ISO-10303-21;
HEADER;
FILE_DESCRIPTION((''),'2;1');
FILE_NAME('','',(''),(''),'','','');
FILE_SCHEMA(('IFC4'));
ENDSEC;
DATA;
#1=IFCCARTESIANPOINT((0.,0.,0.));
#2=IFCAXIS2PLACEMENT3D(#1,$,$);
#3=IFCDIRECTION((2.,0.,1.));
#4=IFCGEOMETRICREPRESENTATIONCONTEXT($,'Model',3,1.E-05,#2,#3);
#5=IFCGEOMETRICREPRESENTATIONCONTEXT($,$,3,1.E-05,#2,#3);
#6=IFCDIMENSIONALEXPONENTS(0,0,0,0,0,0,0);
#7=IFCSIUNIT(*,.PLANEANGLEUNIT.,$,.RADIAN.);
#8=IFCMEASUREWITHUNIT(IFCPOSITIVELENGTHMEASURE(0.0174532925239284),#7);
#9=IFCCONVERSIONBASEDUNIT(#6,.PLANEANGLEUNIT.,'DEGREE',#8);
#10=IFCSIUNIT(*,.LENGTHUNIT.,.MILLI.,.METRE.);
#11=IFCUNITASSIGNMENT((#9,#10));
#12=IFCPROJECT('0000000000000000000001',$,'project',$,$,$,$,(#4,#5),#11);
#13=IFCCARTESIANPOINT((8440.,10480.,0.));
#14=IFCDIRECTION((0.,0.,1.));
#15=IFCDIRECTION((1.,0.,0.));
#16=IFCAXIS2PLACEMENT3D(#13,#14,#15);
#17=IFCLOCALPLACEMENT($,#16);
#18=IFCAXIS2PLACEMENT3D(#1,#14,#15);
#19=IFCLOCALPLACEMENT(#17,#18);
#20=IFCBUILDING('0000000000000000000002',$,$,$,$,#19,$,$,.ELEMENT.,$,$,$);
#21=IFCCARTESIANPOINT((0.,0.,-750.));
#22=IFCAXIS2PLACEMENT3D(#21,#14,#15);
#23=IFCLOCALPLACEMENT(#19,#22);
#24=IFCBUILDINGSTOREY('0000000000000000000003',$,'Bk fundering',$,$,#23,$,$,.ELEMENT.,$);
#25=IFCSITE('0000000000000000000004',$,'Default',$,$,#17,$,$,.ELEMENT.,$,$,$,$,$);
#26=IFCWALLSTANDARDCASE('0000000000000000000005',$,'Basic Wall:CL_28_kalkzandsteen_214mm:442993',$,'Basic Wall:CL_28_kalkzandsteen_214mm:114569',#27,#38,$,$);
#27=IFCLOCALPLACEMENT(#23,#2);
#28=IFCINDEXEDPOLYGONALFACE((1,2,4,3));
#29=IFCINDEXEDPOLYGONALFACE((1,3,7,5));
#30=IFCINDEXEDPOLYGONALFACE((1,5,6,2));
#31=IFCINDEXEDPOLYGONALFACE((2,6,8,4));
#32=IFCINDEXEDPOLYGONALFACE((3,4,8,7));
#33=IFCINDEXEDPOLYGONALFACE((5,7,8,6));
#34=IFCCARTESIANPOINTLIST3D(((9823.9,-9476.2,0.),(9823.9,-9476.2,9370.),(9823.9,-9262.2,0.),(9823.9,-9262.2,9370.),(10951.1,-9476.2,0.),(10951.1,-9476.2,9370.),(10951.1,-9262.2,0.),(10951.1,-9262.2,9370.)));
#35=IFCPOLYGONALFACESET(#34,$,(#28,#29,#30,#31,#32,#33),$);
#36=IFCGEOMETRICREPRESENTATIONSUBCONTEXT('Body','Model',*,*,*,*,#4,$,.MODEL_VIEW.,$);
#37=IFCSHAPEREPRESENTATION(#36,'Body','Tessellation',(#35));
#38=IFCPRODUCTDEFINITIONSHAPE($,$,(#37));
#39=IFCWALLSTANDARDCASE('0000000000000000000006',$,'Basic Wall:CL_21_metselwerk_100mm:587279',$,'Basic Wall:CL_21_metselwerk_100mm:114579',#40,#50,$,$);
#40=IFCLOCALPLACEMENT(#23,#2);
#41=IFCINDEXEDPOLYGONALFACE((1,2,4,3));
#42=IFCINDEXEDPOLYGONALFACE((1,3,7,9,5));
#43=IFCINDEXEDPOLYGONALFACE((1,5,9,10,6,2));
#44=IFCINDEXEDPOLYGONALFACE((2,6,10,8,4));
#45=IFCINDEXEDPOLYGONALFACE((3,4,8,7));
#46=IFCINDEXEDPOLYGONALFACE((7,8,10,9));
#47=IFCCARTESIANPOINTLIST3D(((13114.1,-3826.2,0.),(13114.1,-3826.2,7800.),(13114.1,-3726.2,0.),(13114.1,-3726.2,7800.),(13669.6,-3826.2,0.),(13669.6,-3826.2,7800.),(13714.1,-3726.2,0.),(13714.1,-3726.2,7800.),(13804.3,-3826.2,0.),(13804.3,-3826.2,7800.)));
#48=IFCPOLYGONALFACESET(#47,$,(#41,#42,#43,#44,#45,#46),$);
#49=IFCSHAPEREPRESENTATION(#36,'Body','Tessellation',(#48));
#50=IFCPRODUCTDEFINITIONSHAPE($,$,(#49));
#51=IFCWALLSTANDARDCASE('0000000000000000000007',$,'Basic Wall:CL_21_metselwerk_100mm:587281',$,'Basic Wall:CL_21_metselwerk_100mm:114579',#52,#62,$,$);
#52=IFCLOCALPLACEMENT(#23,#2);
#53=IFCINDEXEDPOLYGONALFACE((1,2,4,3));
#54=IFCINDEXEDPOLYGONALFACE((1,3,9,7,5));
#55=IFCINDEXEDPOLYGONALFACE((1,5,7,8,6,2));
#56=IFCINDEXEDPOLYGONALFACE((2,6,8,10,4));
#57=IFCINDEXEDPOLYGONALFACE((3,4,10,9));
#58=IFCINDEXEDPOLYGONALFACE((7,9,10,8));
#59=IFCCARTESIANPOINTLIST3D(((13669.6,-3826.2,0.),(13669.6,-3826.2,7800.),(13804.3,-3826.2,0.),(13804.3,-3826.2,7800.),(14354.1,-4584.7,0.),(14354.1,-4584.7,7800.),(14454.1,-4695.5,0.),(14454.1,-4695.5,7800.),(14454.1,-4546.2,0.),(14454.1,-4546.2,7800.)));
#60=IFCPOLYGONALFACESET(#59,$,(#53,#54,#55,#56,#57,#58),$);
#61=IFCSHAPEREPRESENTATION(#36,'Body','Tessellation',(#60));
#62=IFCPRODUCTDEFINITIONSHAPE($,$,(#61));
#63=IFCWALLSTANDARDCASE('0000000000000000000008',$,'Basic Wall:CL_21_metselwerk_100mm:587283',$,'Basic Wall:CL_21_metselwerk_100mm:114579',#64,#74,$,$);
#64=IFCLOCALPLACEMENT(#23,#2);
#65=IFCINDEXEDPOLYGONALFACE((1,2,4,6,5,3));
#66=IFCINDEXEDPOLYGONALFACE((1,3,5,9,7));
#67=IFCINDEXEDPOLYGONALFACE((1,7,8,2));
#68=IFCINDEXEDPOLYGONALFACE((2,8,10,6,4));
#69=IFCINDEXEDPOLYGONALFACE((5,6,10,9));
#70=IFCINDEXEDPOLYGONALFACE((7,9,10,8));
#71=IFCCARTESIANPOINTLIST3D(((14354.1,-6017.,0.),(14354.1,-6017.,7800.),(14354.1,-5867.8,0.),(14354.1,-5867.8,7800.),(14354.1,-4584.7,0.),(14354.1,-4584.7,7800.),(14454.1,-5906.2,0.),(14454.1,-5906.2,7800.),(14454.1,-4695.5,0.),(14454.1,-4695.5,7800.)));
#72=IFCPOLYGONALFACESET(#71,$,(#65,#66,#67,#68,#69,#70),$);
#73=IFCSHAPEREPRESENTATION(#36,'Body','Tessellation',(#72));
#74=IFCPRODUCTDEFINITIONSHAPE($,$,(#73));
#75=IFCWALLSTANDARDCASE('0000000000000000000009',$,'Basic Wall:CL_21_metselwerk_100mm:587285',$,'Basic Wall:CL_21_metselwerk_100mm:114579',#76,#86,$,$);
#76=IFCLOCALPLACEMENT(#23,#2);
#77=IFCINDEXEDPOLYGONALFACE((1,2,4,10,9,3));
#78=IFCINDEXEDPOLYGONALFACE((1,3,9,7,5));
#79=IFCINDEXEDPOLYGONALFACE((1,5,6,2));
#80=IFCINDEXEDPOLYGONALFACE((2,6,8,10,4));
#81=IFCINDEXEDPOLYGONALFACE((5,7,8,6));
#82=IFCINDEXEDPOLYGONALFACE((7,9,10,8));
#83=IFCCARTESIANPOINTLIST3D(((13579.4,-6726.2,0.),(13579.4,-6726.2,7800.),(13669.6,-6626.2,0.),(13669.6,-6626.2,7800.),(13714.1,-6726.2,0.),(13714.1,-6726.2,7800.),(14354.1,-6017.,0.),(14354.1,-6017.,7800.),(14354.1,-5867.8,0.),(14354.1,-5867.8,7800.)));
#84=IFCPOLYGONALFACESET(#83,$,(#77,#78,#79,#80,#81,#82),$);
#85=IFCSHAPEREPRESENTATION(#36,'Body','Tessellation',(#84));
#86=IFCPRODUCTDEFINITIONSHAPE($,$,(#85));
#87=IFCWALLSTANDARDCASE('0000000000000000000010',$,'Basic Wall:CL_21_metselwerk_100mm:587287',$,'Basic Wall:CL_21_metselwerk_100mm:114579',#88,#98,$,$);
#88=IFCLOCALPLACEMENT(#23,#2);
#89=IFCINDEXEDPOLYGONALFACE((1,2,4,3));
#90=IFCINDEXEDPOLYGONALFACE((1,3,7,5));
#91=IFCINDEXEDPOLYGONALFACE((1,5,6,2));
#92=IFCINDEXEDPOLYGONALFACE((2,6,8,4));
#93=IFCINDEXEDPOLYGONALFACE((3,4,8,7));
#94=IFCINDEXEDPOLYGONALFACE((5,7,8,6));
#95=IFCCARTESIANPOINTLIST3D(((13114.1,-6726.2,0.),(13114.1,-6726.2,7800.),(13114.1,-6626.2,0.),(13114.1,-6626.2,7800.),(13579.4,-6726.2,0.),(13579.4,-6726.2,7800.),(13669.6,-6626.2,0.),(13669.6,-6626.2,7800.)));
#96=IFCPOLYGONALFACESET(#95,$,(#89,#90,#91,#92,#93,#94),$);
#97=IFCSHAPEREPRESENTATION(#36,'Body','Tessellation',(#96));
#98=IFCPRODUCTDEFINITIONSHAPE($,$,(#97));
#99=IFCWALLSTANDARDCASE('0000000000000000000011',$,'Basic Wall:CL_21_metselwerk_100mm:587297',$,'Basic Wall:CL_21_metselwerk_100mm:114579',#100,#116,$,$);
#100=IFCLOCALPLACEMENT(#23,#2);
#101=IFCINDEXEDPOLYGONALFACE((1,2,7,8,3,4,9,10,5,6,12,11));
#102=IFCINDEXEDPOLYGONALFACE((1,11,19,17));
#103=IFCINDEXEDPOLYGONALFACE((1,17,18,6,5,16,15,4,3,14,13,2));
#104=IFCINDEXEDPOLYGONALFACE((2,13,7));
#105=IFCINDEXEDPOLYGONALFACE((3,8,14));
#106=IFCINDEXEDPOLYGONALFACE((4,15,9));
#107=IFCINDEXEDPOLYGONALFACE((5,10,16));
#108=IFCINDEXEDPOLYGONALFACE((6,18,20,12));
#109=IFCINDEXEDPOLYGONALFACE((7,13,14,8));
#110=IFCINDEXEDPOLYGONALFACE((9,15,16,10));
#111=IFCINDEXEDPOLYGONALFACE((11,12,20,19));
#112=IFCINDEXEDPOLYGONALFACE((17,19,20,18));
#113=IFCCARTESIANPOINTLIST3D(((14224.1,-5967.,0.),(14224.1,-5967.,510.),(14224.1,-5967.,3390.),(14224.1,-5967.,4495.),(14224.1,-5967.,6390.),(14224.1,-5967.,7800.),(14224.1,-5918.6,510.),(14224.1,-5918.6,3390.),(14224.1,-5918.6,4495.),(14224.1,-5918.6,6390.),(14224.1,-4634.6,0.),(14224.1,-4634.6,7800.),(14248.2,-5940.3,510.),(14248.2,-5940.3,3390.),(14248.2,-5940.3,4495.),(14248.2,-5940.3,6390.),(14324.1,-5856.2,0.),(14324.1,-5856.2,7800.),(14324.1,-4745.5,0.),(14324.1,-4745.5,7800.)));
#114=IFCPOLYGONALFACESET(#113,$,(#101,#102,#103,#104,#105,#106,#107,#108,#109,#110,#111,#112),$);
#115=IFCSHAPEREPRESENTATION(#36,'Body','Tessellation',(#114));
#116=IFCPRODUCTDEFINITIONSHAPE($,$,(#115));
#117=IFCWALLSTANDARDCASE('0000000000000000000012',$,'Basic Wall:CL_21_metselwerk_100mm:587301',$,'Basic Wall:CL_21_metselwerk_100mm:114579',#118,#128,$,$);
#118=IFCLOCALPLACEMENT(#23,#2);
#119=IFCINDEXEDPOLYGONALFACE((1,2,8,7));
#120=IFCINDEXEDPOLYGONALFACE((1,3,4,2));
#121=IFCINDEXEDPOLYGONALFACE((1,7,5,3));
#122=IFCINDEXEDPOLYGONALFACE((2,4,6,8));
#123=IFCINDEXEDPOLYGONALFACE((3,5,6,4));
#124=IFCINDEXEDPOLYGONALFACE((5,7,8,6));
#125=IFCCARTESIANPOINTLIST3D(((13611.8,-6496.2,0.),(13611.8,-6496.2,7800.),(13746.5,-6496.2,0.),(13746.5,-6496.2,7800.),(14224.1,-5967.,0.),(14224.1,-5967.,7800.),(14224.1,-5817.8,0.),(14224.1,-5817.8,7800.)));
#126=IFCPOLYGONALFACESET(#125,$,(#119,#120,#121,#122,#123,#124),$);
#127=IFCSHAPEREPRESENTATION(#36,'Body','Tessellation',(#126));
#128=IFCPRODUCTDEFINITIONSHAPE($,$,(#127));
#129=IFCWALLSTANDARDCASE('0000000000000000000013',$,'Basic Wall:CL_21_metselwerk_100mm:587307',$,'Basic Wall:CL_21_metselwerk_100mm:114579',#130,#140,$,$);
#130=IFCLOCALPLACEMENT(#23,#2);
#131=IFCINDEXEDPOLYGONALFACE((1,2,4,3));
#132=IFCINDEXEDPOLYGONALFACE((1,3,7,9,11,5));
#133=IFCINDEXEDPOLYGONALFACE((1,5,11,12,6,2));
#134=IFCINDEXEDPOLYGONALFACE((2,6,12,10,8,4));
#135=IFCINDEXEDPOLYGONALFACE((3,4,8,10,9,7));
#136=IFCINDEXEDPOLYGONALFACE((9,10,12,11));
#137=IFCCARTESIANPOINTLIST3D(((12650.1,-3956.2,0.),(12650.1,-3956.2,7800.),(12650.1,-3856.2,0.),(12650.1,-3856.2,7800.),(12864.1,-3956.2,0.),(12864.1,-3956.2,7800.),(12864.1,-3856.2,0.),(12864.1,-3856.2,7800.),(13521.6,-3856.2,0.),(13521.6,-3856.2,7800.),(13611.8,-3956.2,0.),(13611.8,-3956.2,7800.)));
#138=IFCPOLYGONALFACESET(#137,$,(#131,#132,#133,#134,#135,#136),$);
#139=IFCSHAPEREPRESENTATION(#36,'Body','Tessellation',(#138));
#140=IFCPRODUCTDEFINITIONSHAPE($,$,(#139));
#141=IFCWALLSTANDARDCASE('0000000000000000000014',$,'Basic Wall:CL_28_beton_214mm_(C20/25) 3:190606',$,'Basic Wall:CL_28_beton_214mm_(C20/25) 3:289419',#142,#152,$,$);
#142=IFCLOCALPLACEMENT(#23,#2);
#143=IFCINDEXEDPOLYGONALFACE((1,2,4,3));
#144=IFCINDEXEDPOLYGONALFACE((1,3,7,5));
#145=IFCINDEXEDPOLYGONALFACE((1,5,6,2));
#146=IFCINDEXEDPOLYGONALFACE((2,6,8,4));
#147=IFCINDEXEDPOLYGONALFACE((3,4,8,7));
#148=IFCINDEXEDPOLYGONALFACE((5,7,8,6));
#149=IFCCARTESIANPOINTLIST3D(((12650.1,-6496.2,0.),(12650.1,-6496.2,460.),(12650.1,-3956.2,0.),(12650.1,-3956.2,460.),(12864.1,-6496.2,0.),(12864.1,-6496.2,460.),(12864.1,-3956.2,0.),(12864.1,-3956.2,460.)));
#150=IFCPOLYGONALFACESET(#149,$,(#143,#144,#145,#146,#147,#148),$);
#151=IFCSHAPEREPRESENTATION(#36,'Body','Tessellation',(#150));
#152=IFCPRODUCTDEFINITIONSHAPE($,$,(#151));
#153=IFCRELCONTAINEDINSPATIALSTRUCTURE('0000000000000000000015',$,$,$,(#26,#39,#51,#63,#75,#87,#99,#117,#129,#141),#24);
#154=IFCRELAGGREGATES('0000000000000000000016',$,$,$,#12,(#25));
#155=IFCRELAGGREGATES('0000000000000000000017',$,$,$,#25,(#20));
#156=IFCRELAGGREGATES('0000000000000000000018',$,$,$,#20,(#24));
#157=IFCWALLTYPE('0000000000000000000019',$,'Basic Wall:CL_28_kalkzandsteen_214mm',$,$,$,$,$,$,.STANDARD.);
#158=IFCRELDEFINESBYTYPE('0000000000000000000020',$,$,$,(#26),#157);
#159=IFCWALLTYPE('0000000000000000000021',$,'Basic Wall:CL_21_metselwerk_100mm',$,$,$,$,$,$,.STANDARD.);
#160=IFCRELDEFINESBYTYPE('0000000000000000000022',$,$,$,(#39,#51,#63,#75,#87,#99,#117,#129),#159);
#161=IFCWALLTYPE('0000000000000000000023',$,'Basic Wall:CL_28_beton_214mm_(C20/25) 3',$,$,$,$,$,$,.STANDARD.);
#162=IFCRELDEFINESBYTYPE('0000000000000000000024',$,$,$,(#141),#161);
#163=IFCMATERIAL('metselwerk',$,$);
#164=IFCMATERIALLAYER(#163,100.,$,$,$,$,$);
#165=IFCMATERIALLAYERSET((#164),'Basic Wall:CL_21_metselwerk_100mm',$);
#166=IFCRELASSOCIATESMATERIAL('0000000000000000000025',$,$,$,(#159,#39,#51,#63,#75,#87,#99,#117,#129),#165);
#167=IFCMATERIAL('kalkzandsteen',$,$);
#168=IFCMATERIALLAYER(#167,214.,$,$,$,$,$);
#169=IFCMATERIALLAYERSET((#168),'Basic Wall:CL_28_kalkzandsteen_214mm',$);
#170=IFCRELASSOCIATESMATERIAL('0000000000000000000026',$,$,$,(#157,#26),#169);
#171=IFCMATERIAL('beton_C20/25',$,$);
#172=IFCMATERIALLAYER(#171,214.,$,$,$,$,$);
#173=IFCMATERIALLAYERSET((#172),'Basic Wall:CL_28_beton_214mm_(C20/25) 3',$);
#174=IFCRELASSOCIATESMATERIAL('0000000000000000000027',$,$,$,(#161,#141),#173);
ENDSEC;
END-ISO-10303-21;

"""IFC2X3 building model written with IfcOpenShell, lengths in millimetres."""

from ifc_helpers import new_model, entity, si_unit, converted_unit, direction, frame, frame_2d, origin, origin_with_axes, origin_2d_with_axis, place, context, subcontext, project, spatial, polyline, rectangle, outline, extrude, clip, bounded_halfspace, material, layer, layer_set, layer_usage, type_object, element, save


model = new_model("IFC2X3")

# Units and contexts
model_context = context("Model", 3, precision=1e-05, world=origin(), true_north=direction((2.0, 0.0, 1.0)))
context_of_model = context(None, 3, precision=1e-05, world=origin(), true_north=direction((2.0, 0.0, 1.0)))
body_context = subcontext(model_context, "Body", "Model", "MODEL_VIEW")
ifc_project = project(units=[converted_unit("PLANEANGLEUNIT", "DEGREE", entity("IfcPositiveLengthMeasure", 0.0174532925239284), si_unit("PLANEANGLEUNIT", "RADIAN"), dimensions=[0, 0, 0, 0, 0, 0, 0]), si_unit("LENGTHUNIT", "METRE", prefix="MILLI")], contexts=[model_context, context_of_model])

# Site, building, storey
site_placement = place(None, frame((8440.0, 10480.0, 0.0), z_axis=(0.0, 0.0, 1.0), x_axis=(1.0, 0.0, 0.0)))
site = spatial("IfcSite", under=ifc_project, at=site_placement, Name="Default", CompositionType="ELEMENT")
building_placement = place(site_placement, origin_with_axes())
building = spatial("IfcBuilding", under=site, at=building_placement, CompositionType="ELEMENT")
storey_placement = place(building_placement, frame((0.0, 0.0, -750.0), z_axis=(0.0, 0.0, 1.0), x_axis=(1.0, 0.0, 0.0)))
storey = spatial("IfcBuildingStorey", under=building, at=storey_placement, Name="Bk fundering", CompositionType="ELEMENT")

# Walls
ifc_material_1 = material(Name="metselwerk")
ifc_layer_1 = layer(ifc_material_1, 100.0)
ifc_layer_set_1 = layer_set([ifc_layer_1], Name="Basic Wall:CL_21_metselwerk_100mm")
wall_type_1 = type_object("IfcWallType", Name="Basic Wall:CL_21_metselwerk_100mm", PredefinedType="STANDARD", material=ifc_layer_set_1)
ifc_material_2 = material(Name="kalkzandsteen")
ifc_layer_2 = layer(ifc_material_2, 214.0)
ifc_layer_set_2 = layer_set([ifc_layer_2], Name="Basic Wall:CL_28_kalkzandsteen_214mm")
wall_type_2 = type_object("IfcWallType", Name="Basic Wall:CL_28_kalkzandsteen_214mm", PredefinedType="STANDARD", material=ifc_layer_set_2)
ifc_layer_usage_1 = layer_usage(ifc_layer_set_2, "AXIS2", "POSITIVE", -107.0)
wall_1_placement = place(storey_placement, frame((10951.1, -9369.2, 0.0), z_axis=(0.0, 0.0, 1.0), x_axis=(-1.0, 0.0, 0.0)))
element("IfcWallStandardCase", 1, at=wall_1_placement, inside=storey, type_object=wall_type_2, material=ifc_layer_usage_1, Name="Basic Wall:CL_28_kalkzandsteen_214mm:442993", ObjectType="Basic Wall:CL_28_kalkzandsteen_214mm:114569", context=body_context, shape_type="Clipping", body=[
    clip(extrude(rectangle(XDim=1127.2, YDim=214.0, at=frame_2d((563.6, 0.0), x_axis=(-1.0, 0.0))), origin(), (0.0, 0.0, 1.0), 9370.0), bounded_halfspace(frame((0.0, -107.0, 9370.0), z_axis=(0.0, 0.0, -1.0), x_axis=(-1.0, 0.0, 0.0)), True, frame((0.0, -107.0, 9370.0)), polyline([(0.0, 0.0), (1127.2, 0.0), (1127.2, 214.0), (0.0, 214.0), (0.0, 0.0)]))),
])
ifc_layer_usage_2 = layer_usage(ifc_layer_set_1, "AXIS2", "POSITIVE", -50.0)
wall_2_placement = place(storey_placement, frame((13114.1, -3776.2, 0.0), z_axis=(0.0, 0.0, 1.0), x_axis=(1.0, 0.0, 0.0)))
element("IfcWallStandardCase", 2, at=wall_2_placement, inside=storey, type_object=wall_type_1, material=ifc_layer_usage_2, Name="Basic Wall:CL_21_metselwerk_100mm:587279", ObjectType="Basic Wall:CL_21_metselwerk_100mm:114579", context=body_context, shape_type="SweptSolid", body=[
    extrude(outline(polyline([(690.2, -50.0), (600.0, 50.0), (0.0, 50.0), (0.0, -50.0), (555.5, -50.0), (690.2, -50.0)])), origin(), (0.0, 0.0, 1.0), 7800.0),
])
ifc_layer_usage_3 = layer_usage(ifc_layer_set_1, "AXIS2", "POSITIVE", -50.0)
wall_3_placement = place(storey_placement, frame((13706.7, -3792.7, 0.0), z_axis=(0.0, 0.0, 1.0), x_axis=(0.669965, -0.742393, 0.0)))
element("IfcWallStandardCase", 3, at=wall_3_placement, inside=storey, type_object=wall_type_1, material=ifc_layer_usage_3, Name="Basic Wall:CL_21_metselwerk_100mm:587281", ObjectType="Basic Wall:CL_21_metselwerk_100mm:114579", context=body_context, shape_type="SweptSolid", body=[
    extrude(outline(polyline([(1170.9, -50.0), (1060.1, 50.0), (90.2, 50.0), (0.0, -50.0), (1021.6, -50.0), (1170.9, -50.0)])), origin(), (0.0, 0.0, 1.0), 7800.0),
])
ifc_layer_usage_4 = layer_usage(ifc_layer_set_1, "AXIS2", "POSITIVE", -50.0)
wall_4_placement = place(storey_placement, frame((14404.1, -4584.7, 0.0), z_axis=(0.0, 0.0, 1.0), x_axis=(0.0, -1.0, 0.0)))
element("IfcWallStandardCase", 4, at=wall_4_placement, inside=storey, type_object=wall_type_1, material=ifc_layer_usage_4, Name="Basic Wall:CL_21_metselwerk_100mm:587283", ObjectType="Basic Wall:CL_21_metselwerk_100mm:114579", context=body_context, shape_type="SweptSolid", body=[
    extrude(outline(polyline([(1432.4, -50.0), (1321.5, 50.0), (110.8, 50.0), (0.0, -50.0), (1283.1, -50.0), (1432.4, -50.0)])), origin(), (0.0, 0.0, 1.0), 7800.0),
])
ifc_layer_usage_5 = layer_usage(ifc_layer_set_1, "AXIS2", "POSITIVE", -50.0)
wall_5_placement = place(storey_placement, frame((14391.2, -5901.2, 0.0), z_axis=(0.0, 0.0, 1.0), x_axis=(-0.669965, -0.742393, 0.0)))
element("IfcWallStandardCase", 5, at=wall_5_placement, inside=storey, type_object=wall_type_1, material=ifc_layer_usage_5, Name="Basic Wall:CL_21_metselwerk_100mm:587285", ObjectType="Basic Wall:CL_21_metselwerk_100mm:114579", context=body_context, shape_type="SweptSolid", body=[
    extrude(outline(polyline([(1156.3, -50.0), (1066.1, 50.0), (110.8, 50.0), (0.0, -50.0), (1021.6, -50.0), (1156.3, -50.0)])), origin(), (0.0, 0.0, 1.0), 7800.0),
])
ifc_layer_usage_6 = layer_usage(ifc_layer_set_1, "AXIS2", "NEGATIVE", 50.0)
wall_6_placement = place(storey_placement, frame((13669.6, -6676.2, 0.0), z_axis=(0.0, 0.0, 1.0), x_axis=(-1.0, 0.0, 0.0)))
element("IfcWallStandardCase", 6, at=wall_6_placement, inside=storey, type_object=wall_type_1, material=ifc_layer_usage_6, Name="Basic Wall:CL_21_metselwerk_100mm:587287", ObjectType="Basic Wall:CL_21_metselwerk_100mm:114579", context=body_context, shape_type="SweptSolid", body=[
    extrude(outline(polyline([(555.5, -50.0), (555.5, 50.0), (90.2, 50.0), (0.0, -50.0), (555.5, -50.0)])), origin(), (0.0, 0.0, 1.0), 7800.0),
])

# Wall, openings
ifc_layer_usage_7 = layer_usage(ifc_layer_set_1, "AXIS2", "POSITIVE", -50.0)
wall_7_placement = place(storey_placement, frame((14274.1, -4634.6, 0.0), z_axis=(0.0, 0.0, 1.0), x_axis=(0.0, -1.0, 0.0)))
wall_7 = element("IfcWallStandardCase", 7, at=wall_7_placement, inside=storey, type_object=wall_type_1, material=ifc_layer_usage_7, Name="Basic Wall:CL_21_metselwerk_100mm:587297", ObjectType="Basic Wall:CL_21_metselwerk_100mm:114579", context=body_context, shape_type="SweptSolid", body=[
    extrude(outline(polyline([(1332.4, -50.0), (1221.6, 50.0), (110.8, 50.0), (0.0, -50.0), (1183.1, -50.0), (1332.4, -50.0)])), origin(), (0.0, 0.0, 1.0), 7800.0),
])
opening_1_placement = place(wall_7_placement, origin_with_axes())
element("IfcOpeningElement", 8, at=opening_1_placement, cuts=wall_7, ObjectType="Recess", context=body_context, shape_type="SweptSolid", body=[
    extrude(rectangle(XDim=100.0, YDim=778.0, at=origin_2d_with_axis()), frame((1561.0, -323.6, 510.0), z_axis=(0.0, 0.0, 1.0), x_axis=(-0.669965, -0.742393, 0.0)), (0.0, 0.0, 1.0), 2880.0),
])
opening_2_placement = place(wall_7_placement, origin_with_axes())
element("IfcOpeningElement", 9, at=opening_2_placement, cuts=wall_7, ObjectType="Recess", context=body_context, shape_type="SweptSolid", body=[
    extrude(rectangle(XDim=100.0, YDim=778.0, at=origin_2d_with_axis()), frame((1561.0, -323.6, 4495.0), z_axis=(0.0, 0.0, 1.0), x_axis=(-0.669965, -0.742393, 0.0)), (0.0, 0.0, 1.0), 1895.0),
])

# Wall
ifc_layer_usage_8 = layer_usage(ifc_layer_set_1, "AXIS2", "POSITIVE", -50.0)
wall_8_placement = place(storey_placement, frame((14261.2, -5851.3, 0.0), z_axis=(0.0, 0.0, 1.0), x_axis=(-0.669965, -0.742393, 0.0)))
element("IfcWallStandardCase", 10, at=wall_8_placement, inside=storey, type_object=wall_type_1, material=ifc_layer_usage_8, Name="Basic Wall:CL_21_metselwerk_100mm:587301", ObjectType="Basic Wall:CL_21_metselwerk_100mm:114579", context=body_context, shape_type="SweptSolid", body=[
    extrude(outline(polyline([(913.9, -50.0), (823.6, 50.0), (110.8, 50.0), (0.0, -50.0), (913.9, -50.0)])), origin(), (0.0, 0.0, 1.0), 7800.0),
])

# Walls
ifc_layer_usage_9 = layer_usage(ifc_layer_set_1, "AXIS2", "POSITIVE", -50.0)
wall_9_placement = place(storey_placement, frame((12650.1, -3906.2, 0.0), z_axis=(0.0, 0.0, 1.0), x_axis=(1.0, 0.0, 0.0)))
element("IfcWallStandardCase", 11, at=wall_9_placement, inside=storey, type_object=wall_type_1, material=ifc_layer_usage_9, Name="Basic Wall:CL_21_metselwerk_100mm:587307", ObjectType="Basic Wall:CL_21_metselwerk_100mm:114579", context=body_context, shape_type="SweptSolid", body=[
    extrude(outline(polyline([(961.8, -50.0), (871.5, 50.0), (214.0, 50.0), (0.0, 50.0), (0.0, -50.0), (214.0, -50.0), (961.8, -50.0)])), origin(), (0.0, 0.0, 1.0), 7800.0),
])
ifc_material_3 = material(Name="beton_C20/25")
ifc_layer_3 = layer(ifc_material_3, 214.0)
ifc_layer_set_3 = layer_set([ifc_layer_3], Name="Basic Wall:CL_28_beton_214mm_(C20/25) 3")
ifc_layer_usage_10 = layer_usage(ifc_layer_set_3, "AXIS2", "NEGATIVE", 107.0)
wall_type_3 = type_object("IfcWallType", Name="Basic Wall:CL_28_beton_214mm_(C20/25) 3", PredefinedType="STANDARD", material=ifc_layer_set_3)
wall_10_placement = place(storey_placement, frame((12757.1, -6496.2, 0.0), z_axis=(0.0, 0.0, 1.0), x_axis=(0.0, 1.0, 0.0)))
element("IfcWallStandardCase", 12, at=wall_10_placement, inside=storey, type_object=wall_type_3, material=ifc_layer_usage_10, Name="Basic Wall:CL_28_beton_214mm_(C20/25) 3:190606", ObjectType="Basic Wall:CL_28_beton_214mm_(C20/25) 3:289419", context=body_context, shape_type="Clipping", body=[
    clip(extrude(rectangle(XDim=2540.0, YDim=214.0, at=frame_2d((1270.0, 0.0), x_axis=(-1.0, 0.0))), origin(), (0.0, 0.0, 1.0), 460.0), bounded_halfspace(frame((0.0, -107.0, 460.0), z_axis=(0.0, 0.0, -1.0), x_axis=(-1.0, 0.0, 0.0)), True, frame((0.0, -107.0, 460.0)), polyline([(0.0, 0.0), (2540.0, 0.0), (2540.0, 214.0), (0.0, 214.0), (0.0, 0.0)]))),
])

save(model, "model.ifc")
